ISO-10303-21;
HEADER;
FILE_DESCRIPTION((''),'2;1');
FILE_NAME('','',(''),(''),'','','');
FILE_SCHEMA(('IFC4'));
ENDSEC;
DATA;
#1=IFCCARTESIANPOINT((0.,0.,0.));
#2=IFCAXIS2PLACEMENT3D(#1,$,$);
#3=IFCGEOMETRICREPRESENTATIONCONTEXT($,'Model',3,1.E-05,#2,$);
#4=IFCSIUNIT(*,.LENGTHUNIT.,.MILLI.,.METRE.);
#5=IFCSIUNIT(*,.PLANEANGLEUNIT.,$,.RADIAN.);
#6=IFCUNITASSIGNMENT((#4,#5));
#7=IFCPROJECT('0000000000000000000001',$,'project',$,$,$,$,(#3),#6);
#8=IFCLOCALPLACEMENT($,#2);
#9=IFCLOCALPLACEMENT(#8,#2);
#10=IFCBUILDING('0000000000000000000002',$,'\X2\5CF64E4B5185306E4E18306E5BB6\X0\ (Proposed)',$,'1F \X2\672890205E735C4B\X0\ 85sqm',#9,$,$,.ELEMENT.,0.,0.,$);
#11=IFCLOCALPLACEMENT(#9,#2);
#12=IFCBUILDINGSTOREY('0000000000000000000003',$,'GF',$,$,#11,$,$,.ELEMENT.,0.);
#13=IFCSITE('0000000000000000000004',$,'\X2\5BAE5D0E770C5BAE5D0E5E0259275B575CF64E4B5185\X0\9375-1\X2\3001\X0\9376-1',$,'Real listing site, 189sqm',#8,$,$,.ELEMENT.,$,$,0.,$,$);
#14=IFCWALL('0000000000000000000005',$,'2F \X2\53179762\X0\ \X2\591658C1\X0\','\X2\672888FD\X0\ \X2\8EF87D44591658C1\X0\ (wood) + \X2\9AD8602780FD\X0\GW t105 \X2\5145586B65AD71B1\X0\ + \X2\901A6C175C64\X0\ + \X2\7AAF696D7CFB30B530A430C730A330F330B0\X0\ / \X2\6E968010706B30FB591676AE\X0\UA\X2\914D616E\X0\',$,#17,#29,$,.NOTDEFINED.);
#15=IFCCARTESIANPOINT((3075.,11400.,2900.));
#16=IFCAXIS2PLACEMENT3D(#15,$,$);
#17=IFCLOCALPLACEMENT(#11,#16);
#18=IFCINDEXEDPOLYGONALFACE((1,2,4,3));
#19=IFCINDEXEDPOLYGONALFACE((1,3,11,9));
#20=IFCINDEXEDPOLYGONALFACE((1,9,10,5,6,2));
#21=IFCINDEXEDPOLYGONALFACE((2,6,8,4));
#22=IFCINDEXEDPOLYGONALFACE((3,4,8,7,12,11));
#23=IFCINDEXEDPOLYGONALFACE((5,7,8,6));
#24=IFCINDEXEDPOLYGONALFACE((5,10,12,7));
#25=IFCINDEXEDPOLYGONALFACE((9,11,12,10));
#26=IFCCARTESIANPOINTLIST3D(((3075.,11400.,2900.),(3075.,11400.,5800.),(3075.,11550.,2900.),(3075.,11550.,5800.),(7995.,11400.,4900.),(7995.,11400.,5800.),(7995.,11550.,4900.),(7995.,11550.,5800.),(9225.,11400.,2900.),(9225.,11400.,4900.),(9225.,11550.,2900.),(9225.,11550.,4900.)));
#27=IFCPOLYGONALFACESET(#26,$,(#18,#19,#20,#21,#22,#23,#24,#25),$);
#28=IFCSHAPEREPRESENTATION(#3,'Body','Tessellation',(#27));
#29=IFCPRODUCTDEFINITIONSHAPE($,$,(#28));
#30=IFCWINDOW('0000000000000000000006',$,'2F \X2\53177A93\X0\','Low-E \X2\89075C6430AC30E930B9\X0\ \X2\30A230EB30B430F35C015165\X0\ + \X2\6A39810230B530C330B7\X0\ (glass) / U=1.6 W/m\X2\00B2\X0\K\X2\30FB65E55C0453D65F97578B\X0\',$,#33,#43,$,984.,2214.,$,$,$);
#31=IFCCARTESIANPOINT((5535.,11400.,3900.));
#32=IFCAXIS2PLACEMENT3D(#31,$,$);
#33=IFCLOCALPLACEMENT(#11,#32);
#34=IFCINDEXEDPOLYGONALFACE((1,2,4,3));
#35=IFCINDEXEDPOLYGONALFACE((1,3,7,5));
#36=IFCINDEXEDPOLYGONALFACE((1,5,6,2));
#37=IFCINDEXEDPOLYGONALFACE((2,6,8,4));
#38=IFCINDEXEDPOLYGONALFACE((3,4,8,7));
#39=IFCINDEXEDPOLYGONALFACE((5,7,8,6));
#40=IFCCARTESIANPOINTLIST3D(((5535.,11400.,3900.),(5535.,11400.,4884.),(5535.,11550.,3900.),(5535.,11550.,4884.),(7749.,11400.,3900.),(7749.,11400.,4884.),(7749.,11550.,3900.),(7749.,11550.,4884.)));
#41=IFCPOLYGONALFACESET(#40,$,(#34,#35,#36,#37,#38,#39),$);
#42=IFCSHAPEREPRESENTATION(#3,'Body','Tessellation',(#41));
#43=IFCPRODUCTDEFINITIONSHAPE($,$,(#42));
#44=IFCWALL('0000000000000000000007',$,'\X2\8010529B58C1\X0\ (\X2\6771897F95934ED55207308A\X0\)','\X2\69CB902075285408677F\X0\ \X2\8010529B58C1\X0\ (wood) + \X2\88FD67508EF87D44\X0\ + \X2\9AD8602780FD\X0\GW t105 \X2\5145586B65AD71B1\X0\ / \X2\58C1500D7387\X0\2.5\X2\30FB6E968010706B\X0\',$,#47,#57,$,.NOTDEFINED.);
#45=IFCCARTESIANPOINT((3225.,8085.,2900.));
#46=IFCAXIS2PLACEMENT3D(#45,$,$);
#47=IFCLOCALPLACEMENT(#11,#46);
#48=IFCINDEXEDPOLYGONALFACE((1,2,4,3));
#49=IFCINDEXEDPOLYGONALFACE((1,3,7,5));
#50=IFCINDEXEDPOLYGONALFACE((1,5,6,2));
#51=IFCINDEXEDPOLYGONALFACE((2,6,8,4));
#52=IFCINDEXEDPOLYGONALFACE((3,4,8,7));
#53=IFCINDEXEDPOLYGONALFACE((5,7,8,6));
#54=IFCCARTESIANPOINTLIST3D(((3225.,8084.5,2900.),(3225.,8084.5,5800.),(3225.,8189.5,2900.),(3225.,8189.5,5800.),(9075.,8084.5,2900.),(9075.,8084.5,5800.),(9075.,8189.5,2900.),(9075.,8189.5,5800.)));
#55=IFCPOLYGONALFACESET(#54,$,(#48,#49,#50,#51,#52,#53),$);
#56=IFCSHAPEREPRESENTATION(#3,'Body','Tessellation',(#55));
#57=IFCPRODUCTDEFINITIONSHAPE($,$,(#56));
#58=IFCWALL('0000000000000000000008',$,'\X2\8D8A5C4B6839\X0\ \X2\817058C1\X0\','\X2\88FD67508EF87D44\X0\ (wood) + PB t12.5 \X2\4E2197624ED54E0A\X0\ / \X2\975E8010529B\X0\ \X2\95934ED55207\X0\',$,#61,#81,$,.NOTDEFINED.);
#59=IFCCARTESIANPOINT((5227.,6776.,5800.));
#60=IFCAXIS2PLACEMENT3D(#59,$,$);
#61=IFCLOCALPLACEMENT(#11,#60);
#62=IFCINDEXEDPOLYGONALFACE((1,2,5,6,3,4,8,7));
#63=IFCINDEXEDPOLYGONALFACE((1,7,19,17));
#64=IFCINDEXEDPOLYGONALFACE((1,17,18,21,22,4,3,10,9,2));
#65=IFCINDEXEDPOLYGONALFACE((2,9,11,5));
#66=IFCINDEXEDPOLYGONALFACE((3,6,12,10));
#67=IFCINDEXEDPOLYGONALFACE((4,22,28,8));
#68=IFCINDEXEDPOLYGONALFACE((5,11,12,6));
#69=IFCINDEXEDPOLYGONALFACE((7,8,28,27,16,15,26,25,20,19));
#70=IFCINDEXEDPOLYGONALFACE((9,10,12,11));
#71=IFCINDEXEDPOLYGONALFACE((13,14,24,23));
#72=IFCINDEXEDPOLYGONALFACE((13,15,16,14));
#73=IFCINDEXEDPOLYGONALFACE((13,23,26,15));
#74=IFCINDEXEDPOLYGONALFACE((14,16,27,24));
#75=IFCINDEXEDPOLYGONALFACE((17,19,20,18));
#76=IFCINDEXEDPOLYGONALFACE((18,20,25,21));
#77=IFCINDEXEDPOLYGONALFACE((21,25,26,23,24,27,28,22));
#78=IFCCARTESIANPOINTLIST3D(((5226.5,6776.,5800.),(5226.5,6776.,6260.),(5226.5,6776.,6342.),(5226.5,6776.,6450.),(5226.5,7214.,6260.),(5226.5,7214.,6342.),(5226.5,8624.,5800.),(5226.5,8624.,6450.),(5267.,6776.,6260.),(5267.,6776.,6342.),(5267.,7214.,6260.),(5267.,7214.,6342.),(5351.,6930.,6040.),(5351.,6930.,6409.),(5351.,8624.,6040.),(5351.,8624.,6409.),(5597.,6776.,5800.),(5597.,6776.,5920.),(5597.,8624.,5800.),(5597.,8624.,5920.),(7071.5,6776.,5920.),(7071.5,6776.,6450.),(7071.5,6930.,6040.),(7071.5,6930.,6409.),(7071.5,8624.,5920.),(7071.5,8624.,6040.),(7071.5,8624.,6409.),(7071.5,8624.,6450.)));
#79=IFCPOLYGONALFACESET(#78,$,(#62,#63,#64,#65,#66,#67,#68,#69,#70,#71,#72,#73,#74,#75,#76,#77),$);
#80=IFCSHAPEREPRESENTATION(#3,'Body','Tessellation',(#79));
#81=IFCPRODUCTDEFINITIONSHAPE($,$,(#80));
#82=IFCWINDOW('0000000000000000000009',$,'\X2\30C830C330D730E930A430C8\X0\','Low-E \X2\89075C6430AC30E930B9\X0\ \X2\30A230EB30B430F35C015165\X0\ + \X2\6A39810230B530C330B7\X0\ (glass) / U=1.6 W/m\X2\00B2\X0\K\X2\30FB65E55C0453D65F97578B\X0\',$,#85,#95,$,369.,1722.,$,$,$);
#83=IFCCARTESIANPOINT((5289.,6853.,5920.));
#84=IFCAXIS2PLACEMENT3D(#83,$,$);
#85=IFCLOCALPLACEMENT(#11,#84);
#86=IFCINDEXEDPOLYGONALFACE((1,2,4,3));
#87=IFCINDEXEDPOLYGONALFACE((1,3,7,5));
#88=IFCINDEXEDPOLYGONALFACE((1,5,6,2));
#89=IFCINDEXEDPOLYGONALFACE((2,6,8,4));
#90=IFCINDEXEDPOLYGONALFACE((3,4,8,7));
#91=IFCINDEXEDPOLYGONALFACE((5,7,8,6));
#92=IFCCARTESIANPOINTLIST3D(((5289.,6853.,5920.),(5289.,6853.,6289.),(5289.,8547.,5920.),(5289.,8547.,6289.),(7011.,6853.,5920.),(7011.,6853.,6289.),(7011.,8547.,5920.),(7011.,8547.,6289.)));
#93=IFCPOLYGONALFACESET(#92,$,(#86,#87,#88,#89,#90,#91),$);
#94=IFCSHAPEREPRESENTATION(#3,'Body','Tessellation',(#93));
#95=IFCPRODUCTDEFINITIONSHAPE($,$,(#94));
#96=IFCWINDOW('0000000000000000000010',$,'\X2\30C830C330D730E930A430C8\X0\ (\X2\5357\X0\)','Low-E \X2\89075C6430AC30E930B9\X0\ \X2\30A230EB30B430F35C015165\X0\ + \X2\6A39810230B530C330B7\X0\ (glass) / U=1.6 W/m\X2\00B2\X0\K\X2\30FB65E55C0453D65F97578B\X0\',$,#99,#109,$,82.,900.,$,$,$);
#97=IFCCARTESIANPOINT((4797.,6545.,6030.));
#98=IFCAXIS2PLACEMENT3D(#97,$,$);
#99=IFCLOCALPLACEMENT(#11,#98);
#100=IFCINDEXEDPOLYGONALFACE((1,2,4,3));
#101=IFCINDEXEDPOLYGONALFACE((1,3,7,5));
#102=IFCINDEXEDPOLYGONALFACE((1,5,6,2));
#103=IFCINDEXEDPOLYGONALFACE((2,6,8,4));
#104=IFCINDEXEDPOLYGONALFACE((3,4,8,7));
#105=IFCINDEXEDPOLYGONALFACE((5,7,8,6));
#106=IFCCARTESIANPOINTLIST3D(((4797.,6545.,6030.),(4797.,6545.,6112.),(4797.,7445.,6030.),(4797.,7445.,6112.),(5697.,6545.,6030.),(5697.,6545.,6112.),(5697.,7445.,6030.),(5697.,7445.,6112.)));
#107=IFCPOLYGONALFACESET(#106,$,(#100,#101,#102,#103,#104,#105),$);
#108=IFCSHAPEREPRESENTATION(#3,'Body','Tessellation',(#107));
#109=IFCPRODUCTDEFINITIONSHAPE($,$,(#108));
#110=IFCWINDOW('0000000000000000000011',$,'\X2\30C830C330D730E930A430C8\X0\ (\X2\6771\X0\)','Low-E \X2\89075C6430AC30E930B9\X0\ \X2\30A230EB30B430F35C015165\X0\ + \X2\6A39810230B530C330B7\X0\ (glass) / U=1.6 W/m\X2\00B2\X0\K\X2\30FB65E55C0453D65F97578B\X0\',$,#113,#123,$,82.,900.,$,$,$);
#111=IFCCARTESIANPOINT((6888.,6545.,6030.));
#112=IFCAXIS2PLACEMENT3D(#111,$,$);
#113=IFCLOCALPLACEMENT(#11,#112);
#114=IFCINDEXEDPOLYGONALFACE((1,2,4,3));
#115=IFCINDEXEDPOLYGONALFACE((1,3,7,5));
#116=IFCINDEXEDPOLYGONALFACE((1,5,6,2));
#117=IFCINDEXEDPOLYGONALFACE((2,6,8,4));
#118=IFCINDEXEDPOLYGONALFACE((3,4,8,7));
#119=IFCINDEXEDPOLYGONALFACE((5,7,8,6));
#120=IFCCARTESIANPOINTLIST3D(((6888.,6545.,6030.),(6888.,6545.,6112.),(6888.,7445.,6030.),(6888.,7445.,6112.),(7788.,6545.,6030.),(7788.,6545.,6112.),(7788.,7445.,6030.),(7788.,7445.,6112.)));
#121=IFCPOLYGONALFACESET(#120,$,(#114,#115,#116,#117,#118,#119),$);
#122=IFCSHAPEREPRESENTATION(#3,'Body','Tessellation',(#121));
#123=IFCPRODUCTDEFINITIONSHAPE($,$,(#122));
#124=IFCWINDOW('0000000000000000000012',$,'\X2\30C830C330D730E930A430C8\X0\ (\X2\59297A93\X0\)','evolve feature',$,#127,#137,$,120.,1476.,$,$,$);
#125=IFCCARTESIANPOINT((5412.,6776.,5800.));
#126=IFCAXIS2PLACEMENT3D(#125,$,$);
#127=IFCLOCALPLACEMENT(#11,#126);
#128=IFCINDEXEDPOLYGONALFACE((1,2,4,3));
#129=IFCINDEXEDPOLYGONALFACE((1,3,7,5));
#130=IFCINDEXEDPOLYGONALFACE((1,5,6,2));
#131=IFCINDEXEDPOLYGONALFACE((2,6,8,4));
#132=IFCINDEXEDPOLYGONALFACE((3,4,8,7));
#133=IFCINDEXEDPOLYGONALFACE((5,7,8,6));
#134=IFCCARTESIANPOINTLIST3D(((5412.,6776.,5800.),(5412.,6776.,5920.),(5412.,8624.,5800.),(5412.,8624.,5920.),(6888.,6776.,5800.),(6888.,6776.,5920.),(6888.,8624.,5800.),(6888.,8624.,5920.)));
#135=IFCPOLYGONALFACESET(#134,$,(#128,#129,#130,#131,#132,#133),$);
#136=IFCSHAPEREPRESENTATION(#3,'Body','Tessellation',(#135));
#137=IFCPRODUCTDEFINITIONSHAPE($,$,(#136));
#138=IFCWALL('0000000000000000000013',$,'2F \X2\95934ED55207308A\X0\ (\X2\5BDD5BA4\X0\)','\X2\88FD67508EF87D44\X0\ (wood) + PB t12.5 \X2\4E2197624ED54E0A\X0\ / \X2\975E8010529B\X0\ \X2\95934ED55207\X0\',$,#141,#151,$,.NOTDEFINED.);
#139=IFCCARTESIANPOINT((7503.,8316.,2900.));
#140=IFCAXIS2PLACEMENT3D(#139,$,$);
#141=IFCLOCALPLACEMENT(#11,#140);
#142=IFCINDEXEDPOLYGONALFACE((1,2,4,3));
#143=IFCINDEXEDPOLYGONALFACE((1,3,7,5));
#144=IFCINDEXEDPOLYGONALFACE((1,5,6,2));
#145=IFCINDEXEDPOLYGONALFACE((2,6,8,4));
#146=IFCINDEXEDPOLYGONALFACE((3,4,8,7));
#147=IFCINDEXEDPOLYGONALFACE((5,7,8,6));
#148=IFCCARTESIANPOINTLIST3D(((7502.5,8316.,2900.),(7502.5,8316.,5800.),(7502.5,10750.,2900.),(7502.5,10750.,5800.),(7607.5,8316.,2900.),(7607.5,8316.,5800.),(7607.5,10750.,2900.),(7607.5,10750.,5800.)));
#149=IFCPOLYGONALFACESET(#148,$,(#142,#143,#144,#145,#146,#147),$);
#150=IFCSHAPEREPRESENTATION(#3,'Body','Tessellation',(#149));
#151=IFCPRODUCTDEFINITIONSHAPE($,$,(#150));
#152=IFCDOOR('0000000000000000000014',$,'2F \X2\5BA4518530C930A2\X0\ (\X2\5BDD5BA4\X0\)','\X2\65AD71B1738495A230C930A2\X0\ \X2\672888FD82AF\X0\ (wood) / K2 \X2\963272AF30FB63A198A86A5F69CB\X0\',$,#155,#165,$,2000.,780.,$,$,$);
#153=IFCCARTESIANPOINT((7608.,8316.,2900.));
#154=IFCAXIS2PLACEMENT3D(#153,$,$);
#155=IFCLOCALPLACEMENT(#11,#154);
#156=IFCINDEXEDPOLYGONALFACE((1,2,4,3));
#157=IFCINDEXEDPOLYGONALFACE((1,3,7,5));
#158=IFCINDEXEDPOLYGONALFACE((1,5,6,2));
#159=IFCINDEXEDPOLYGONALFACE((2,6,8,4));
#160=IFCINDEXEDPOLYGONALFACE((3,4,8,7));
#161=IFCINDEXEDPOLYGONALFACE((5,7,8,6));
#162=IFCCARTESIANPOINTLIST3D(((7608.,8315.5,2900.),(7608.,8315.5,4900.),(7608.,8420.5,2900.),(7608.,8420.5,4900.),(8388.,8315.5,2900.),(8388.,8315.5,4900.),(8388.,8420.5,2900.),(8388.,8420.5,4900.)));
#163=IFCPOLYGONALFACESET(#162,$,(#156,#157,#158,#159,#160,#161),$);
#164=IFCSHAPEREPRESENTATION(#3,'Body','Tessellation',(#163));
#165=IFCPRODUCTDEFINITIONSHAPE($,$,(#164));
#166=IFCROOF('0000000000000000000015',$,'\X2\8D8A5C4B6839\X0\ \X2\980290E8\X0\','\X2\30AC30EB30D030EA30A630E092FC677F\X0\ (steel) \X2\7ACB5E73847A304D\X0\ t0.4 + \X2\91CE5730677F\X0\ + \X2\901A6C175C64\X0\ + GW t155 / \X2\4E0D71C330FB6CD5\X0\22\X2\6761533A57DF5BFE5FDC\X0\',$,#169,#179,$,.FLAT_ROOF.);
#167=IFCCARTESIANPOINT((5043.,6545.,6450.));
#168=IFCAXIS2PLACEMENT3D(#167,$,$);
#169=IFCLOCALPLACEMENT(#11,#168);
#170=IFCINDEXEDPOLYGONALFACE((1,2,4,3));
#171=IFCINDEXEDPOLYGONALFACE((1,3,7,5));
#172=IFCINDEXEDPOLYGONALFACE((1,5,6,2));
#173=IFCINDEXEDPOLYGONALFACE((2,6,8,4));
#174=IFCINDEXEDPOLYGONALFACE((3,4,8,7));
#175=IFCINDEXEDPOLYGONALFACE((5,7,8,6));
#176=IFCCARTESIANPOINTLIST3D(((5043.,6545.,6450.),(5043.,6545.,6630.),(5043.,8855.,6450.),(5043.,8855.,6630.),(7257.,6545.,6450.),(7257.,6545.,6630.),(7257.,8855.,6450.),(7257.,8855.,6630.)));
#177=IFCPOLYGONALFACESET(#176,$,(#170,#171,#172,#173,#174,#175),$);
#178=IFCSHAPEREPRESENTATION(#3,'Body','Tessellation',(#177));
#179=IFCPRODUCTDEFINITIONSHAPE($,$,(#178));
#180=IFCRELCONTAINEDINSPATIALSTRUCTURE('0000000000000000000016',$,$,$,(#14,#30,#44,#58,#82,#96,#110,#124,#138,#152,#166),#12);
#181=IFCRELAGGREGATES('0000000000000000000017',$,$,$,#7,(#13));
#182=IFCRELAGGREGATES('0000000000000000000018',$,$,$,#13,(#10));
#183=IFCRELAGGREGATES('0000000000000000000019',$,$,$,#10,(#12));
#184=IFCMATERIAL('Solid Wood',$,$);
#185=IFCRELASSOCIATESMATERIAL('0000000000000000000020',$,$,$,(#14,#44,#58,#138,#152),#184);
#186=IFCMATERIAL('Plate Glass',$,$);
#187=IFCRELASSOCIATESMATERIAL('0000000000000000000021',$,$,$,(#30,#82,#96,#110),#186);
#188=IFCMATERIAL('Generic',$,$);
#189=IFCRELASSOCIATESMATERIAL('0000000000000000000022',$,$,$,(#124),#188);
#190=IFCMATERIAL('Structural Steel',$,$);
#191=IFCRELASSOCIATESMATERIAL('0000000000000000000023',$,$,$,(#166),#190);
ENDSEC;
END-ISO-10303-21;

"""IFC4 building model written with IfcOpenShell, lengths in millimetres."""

from ifc_helpers import new_model, si_unit, frame, frame_2d, origin, place, context, project, spatial, rectangle, extrude, material, element, fill, save


model = new_model("IFC4")

# Units and contexts
model_context = context("Model", 3, precision=1e-05, world=origin())
ifc_project = project(units=[si_unit("LENGTHUNIT", "METRE", prefix="MILLI"), si_unit("PLANEANGLEUNIT", "RADIAN")], contexts=[model_context])

# Site, building, storey
site_placement = place(None, origin())
site = spatial("IfcSite", under=ifc_project, at=site_placement, Name="宮崎県宮崎市大字島之内9375-1、9376-1", ObjectType="Real listing site, 189sqm", CompositionType="ELEMENT", RefElevation=0.0)
building_placement = place(site_placement, origin())
building = spatial("IfcBuilding", under=site, at=building_placement, Name="島之内の丘の家 (Proposed)", ObjectType="1F 木造平屋 85sqm", CompositionType="ELEMENT", ElevationOfRefHeight=0.0, ElevationOfTerrain=0.0)
storey_placement = place(building_placement, origin())
storey = spatial("IfcBuildingStorey", under=building, at=storey_placement, Name="GF", CompositionType="ELEMENT", Elevation=0.0)

# Wall, opening, window
ifc_material_1 = material(Name="Solid Wood")
wall_1_placement = place(storey_placement, frame((3075.0, 11400.0, 2900.0)))
wall_1 = element("IfcWall", 1, at=wall_1_placement, inside=storey, material=ifc_material_1, Name="2F 北面 外壁", Description="木製 軸組外壁 (wood) + 高性能GW t105 充填断熱 + 通気層 + 窯業系サイディング / 準耐火・外皮UA配慮", PredefinedType="NOTDEFINED", context=model_context, shape_type="SweptSolid", body=[
    extrude(rectangle(XDim=6150.0, YDim=150.0, at=frame_2d((3075.0, 75.0))), frame((3075.0, 11400.0, 2900.0)), (0.0, 0.0, 1.0), 2900.0),
])
opening_1_placement = place(storey_placement, frame((5535.0, 11400.0, 3900.0)))
opening_1 = element("IfcOpeningElement", 2, at=opening_1_placement, cuts=wall_1, PredefinedType="NOTDEFINED", context=model_context, shape_type="SweptSolid", body=[
    extrude(rectangle(XDim=2214.0, YDim=150.0, at=frame_2d((1107.0, 75.0))), frame((5535.0, 11400.0, 3900.0)), (0.0, 0.0, 1.0), 984.0),
])
ifc_material_2 = material(Name="Plate Glass")
window_1_placement = place(storey_placement, frame((5535.0, 11400.0, 3900.0)))
window_1 = element("IfcWindow", 3, at=window_1_placement, inside=storey, material=ifc_material_2, Name="2F 北窓", Description="Low-E 複層ガラス アルゴン封入 + 樹脂サッシ (glass) / U=1.6 W/m²K・日射取得型", OverallHeight=984.0, OverallWidth=2214.0, context=model_context, shape_type="SweptSolid", body=[
    extrude(rectangle(XDim=2214.0, YDim=150.0, at=frame_2d((1107.0, 75.0))), frame((5535.0, 11400.0, 3900.0)), (0.0, 0.0, 1.0), 984.0),
])
fill(opening_1, window_1)

# Wall
wall_2_placement = place(storey_placement, frame((3225.0, 8085.0, 2900.0)))
element("IfcWall", 4, at=wall_2_placement, inside=storey, material=ifc_material_1, Name="耐力壁 (東西間仕切り)", Description="構造用合板 耐力壁 (wood) + 製材軸組 + 高性能GW t105 充填断熱 / 壁倍率2.5・準耐火", PredefinedType="NOTDEFINED", context=model_context, shape_type="SweptSolid", body=[
    extrude(rectangle(XDim=5850.0, YDim=105.0, at=frame_2d((2925.0, 52.0))), frame((3225.0, 8085.0, 2900.0)), (0.0, 0.0, 1.0), 2900.0),
])

# Wall, openings, windows
wall_3_placement = place(storey_placement, frame((5227.0, 6776.0, 5800.0)))
wall_3 = element("IfcWall", 5, at=wall_3_placement, inside=storey, material=ifc_material_1, Name="越屋根 腰壁", Description="製材軸組 (wood) + PB t12.5 両面仕上 / 非耐力 間仕切", PredefinedType="NOTDEFINED", context=model_context, shape_type="SweptSolid", body=[
    extrude(rectangle(XDim=1845.0, YDim=1848.0, at=frame_2d((922.0, 924.0))), frame((5227.0, 6776.0, 5800.0)), (0.0, 0.0, 1.0), 650.0),
])
opening_2_placement = place(storey_placement, frame((5289.0, 6853.0, 5920.0)))
opening_2 = element("IfcOpeningElement", 6, at=opening_2_placement, cuts=wall_3, PredefinedType="NOTDEFINED", context=model_context, shape_type="SweptSolid", body=[
    extrude(rectangle(XDim=1722.0, YDim=1694.0, at=frame_2d((861.0, 847.0))), frame((5289.0, 6853.0, 5920.0)), (0.0, 0.0, 1.0), 369.0),
])
opening_3_placement = place(storey_placement, frame((4797.0, 6545.0, 6030.0)))
opening_3 = element("IfcOpeningElement", 7, at=opening_3_placement, cuts=wall_3, PredefinedType="NOTDEFINED", context=model_context, shape_type="SweptSolid", body=[
    extrude(rectangle(XDim=900.0, YDim=900.0, at=frame_2d((450.0, 450.0))), frame((4797.0, 6545.0, 6030.0)), (0.0, 0.0, 1.0), 82.0),
])
opening_4_placement = place(storey_placement, frame((6888.0, 6545.0, 6030.0)))
opening_4 = element("IfcOpeningElement", 8, at=opening_4_placement, cuts=wall_3, PredefinedType="NOTDEFINED", context=model_context, shape_type="SweptSolid", body=[
    extrude(rectangle(XDim=900.0, YDim=900.0, at=frame_2d((450.0, 450.0))), frame((6888.0, 6545.0, 6030.0)), (0.0, 0.0, 1.0), 82.0),
])
opening_5_placement = place(storey_placement, frame((5412.0, 6776.0, 5800.0)))
opening_5 = element("IfcOpeningElement", 9, at=opening_5_placement, cuts=wall_3, PredefinedType="NOTDEFINED", context=model_context, shape_type="SweptSolid", body=[
    extrude(rectangle(XDim=1476.0, YDim=1848.0, at=frame_2d((738.0, 924.0))), frame((5412.0, 6776.0, 5800.0)), (0.0, 0.0, 1.0), 120.0),
])
window_2_placement = place(storey_placement, frame((5289.0, 6853.0, 5920.0)))
window_2 = element("IfcWindow", 10, at=window_2_placement, inside=storey, material=ifc_material_2, Name="トップライト", Description="Low-E 複層ガラス アルゴン封入 + 樹脂サッシ (glass) / U=1.6 W/m²K・日射取得型", OverallHeight=369.0, OverallWidth=1722.0, context=model_context, shape_type="SweptSolid", body=[
    extrude(rectangle(XDim=1722.0, YDim=1694.0, at=frame_2d((861.0, 847.0))), frame((5289.0, 6853.0, 5920.0)), (0.0, 0.0, 1.0), 369.0),
])
fill(opening_2, window_2)
window_3_placement = place(storey_placement, frame((4797.0, 6545.0, 6030.0)))
window_3 = element("IfcWindow", 11, at=window_3_placement, inside=storey, material=ifc_material_2, Name="トップライト (南)", Description="Low-E 複層ガラス アルゴン封入 + 樹脂サッシ (glass) / U=1.6 W/m²K・日射取得型", OverallHeight=82.0, OverallWidth=900.0, context=model_context, shape_type="SweptSolid", body=[
    extrude(rectangle(XDim=900.0, YDim=900.0, at=frame_2d((450.0, 450.0))), frame((4797.0, 6545.0, 6030.0)), (0.0, 0.0, 1.0), 82.0),
])
fill(opening_3, window_3)
window_4_placement = place(storey_placement, frame((6888.0, 6545.0, 6030.0)))
window_4 = element("IfcWindow", 12, at=window_4_placement, inside=storey, material=ifc_material_2, Name="トップライト (東)", Description="Low-E 複層ガラス アルゴン封入 + 樹脂サッシ (glass) / U=1.6 W/m²K・日射取得型", OverallHeight=82.0, OverallWidth=900.0, context=model_context, shape_type="SweptSolid", body=[
    extrude(rectangle(XDim=900.0, YDim=900.0, at=frame_2d((450.0, 450.0))), frame((6888.0, 6545.0, 6030.0)), (0.0, 0.0, 1.0), 82.0),
])
fill(opening_4, window_4)
ifc_material_3 = material(Name="Generic")
window_5_placement = place(storey_placement, frame((5412.0, 6776.0, 5800.0)))
window_5 = element("IfcWindow", 13, at=window_5_placement, inside=storey, material=ifc_material_3, Name="トップライト (天窓)", Description="evolve feature", OverallHeight=120.0, OverallWidth=1476.0, context=model_context, shape_type="SweptSolid", body=[
    extrude(rectangle(XDim=1476.0, YDim=1848.0, at=frame_2d((738.0, 924.0))), frame((5412.0, 6776.0, 5800.0)), (0.0, 0.0, 1.0), 120.0),
])
fill(opening_5, window_5)

# Wall
wall_4_placement = place(storey_placement, frame((7503.0, 8316.0, 2900.0)))
element("IfcWall", 14, at=wall_4_placement, inside=storey, material=ifc_material_1, Name="2F 間仕切り (寝室)", Description="製材軸組 (wood) + PB t12.5 両面仕上 / 非耐力 間仕切", PredefinedType="NOTDEFINED", context=model_context, shape_type="SweptSolid", body=[
    extrude(rectangle(XDim=105.0, YDim=2434.0, at=frame_2d((52.0, 1217.0))), frame((7503.0, 8316.0, 2900.0)), (0.0, 0.0, 1.0), 2900.0),
])

# Door
door_placement = place(storey_placement, frame((7608.0, 8316.0, 2900.0)))
element("IfcDoor", 15, at=door_placement, inside=storey, material=ifc_material_1, Name="2F 室内ドア (寝室)", Description="断熱玄関ドア 木製芯 (wood) / K2 防犯・採風機構", OverallHeight=2000.0, OverallWidth=780.0, context=model_context, shape_type="SweptSolid", body=[
    extrude(rectangle(XDim=780.0, YDim=105.0, at=frame_2d((390.0, 52.0))), frame((7608.0, 8316.0, 2900.0)), (0.0, 0.0, 1.0), 2000.0),
])

# Roof
ifc_material_4 = material(Name="Structural Steel")
roof_placement = place(storey_placement, frame((5043.0, 6545.0, 6450.0)))
element("IfcRoof", 16, at=roof_placement, inside=storey, material=ifc_material_4, Name="越屋根 頂部", Description="ガルバリウム鋼板 (steel) 立平葺き t0.4 + 野地板 + 通気層 + GW t155 / 不燃・法22条区域対応", PredefinedType="FLAT_ROOF", context=model_context, shape_type="SweptSolid", body=[
    extrude(rectangle(XDim=2214.0, YDim=2310.0, at=frame_2d((1107.0, 1155.0))), frame((5043.0, 6545.0, 6450.0)), (0.0, 0.0, 1.0), 180.0),
])

save(model, "model.ifc")
